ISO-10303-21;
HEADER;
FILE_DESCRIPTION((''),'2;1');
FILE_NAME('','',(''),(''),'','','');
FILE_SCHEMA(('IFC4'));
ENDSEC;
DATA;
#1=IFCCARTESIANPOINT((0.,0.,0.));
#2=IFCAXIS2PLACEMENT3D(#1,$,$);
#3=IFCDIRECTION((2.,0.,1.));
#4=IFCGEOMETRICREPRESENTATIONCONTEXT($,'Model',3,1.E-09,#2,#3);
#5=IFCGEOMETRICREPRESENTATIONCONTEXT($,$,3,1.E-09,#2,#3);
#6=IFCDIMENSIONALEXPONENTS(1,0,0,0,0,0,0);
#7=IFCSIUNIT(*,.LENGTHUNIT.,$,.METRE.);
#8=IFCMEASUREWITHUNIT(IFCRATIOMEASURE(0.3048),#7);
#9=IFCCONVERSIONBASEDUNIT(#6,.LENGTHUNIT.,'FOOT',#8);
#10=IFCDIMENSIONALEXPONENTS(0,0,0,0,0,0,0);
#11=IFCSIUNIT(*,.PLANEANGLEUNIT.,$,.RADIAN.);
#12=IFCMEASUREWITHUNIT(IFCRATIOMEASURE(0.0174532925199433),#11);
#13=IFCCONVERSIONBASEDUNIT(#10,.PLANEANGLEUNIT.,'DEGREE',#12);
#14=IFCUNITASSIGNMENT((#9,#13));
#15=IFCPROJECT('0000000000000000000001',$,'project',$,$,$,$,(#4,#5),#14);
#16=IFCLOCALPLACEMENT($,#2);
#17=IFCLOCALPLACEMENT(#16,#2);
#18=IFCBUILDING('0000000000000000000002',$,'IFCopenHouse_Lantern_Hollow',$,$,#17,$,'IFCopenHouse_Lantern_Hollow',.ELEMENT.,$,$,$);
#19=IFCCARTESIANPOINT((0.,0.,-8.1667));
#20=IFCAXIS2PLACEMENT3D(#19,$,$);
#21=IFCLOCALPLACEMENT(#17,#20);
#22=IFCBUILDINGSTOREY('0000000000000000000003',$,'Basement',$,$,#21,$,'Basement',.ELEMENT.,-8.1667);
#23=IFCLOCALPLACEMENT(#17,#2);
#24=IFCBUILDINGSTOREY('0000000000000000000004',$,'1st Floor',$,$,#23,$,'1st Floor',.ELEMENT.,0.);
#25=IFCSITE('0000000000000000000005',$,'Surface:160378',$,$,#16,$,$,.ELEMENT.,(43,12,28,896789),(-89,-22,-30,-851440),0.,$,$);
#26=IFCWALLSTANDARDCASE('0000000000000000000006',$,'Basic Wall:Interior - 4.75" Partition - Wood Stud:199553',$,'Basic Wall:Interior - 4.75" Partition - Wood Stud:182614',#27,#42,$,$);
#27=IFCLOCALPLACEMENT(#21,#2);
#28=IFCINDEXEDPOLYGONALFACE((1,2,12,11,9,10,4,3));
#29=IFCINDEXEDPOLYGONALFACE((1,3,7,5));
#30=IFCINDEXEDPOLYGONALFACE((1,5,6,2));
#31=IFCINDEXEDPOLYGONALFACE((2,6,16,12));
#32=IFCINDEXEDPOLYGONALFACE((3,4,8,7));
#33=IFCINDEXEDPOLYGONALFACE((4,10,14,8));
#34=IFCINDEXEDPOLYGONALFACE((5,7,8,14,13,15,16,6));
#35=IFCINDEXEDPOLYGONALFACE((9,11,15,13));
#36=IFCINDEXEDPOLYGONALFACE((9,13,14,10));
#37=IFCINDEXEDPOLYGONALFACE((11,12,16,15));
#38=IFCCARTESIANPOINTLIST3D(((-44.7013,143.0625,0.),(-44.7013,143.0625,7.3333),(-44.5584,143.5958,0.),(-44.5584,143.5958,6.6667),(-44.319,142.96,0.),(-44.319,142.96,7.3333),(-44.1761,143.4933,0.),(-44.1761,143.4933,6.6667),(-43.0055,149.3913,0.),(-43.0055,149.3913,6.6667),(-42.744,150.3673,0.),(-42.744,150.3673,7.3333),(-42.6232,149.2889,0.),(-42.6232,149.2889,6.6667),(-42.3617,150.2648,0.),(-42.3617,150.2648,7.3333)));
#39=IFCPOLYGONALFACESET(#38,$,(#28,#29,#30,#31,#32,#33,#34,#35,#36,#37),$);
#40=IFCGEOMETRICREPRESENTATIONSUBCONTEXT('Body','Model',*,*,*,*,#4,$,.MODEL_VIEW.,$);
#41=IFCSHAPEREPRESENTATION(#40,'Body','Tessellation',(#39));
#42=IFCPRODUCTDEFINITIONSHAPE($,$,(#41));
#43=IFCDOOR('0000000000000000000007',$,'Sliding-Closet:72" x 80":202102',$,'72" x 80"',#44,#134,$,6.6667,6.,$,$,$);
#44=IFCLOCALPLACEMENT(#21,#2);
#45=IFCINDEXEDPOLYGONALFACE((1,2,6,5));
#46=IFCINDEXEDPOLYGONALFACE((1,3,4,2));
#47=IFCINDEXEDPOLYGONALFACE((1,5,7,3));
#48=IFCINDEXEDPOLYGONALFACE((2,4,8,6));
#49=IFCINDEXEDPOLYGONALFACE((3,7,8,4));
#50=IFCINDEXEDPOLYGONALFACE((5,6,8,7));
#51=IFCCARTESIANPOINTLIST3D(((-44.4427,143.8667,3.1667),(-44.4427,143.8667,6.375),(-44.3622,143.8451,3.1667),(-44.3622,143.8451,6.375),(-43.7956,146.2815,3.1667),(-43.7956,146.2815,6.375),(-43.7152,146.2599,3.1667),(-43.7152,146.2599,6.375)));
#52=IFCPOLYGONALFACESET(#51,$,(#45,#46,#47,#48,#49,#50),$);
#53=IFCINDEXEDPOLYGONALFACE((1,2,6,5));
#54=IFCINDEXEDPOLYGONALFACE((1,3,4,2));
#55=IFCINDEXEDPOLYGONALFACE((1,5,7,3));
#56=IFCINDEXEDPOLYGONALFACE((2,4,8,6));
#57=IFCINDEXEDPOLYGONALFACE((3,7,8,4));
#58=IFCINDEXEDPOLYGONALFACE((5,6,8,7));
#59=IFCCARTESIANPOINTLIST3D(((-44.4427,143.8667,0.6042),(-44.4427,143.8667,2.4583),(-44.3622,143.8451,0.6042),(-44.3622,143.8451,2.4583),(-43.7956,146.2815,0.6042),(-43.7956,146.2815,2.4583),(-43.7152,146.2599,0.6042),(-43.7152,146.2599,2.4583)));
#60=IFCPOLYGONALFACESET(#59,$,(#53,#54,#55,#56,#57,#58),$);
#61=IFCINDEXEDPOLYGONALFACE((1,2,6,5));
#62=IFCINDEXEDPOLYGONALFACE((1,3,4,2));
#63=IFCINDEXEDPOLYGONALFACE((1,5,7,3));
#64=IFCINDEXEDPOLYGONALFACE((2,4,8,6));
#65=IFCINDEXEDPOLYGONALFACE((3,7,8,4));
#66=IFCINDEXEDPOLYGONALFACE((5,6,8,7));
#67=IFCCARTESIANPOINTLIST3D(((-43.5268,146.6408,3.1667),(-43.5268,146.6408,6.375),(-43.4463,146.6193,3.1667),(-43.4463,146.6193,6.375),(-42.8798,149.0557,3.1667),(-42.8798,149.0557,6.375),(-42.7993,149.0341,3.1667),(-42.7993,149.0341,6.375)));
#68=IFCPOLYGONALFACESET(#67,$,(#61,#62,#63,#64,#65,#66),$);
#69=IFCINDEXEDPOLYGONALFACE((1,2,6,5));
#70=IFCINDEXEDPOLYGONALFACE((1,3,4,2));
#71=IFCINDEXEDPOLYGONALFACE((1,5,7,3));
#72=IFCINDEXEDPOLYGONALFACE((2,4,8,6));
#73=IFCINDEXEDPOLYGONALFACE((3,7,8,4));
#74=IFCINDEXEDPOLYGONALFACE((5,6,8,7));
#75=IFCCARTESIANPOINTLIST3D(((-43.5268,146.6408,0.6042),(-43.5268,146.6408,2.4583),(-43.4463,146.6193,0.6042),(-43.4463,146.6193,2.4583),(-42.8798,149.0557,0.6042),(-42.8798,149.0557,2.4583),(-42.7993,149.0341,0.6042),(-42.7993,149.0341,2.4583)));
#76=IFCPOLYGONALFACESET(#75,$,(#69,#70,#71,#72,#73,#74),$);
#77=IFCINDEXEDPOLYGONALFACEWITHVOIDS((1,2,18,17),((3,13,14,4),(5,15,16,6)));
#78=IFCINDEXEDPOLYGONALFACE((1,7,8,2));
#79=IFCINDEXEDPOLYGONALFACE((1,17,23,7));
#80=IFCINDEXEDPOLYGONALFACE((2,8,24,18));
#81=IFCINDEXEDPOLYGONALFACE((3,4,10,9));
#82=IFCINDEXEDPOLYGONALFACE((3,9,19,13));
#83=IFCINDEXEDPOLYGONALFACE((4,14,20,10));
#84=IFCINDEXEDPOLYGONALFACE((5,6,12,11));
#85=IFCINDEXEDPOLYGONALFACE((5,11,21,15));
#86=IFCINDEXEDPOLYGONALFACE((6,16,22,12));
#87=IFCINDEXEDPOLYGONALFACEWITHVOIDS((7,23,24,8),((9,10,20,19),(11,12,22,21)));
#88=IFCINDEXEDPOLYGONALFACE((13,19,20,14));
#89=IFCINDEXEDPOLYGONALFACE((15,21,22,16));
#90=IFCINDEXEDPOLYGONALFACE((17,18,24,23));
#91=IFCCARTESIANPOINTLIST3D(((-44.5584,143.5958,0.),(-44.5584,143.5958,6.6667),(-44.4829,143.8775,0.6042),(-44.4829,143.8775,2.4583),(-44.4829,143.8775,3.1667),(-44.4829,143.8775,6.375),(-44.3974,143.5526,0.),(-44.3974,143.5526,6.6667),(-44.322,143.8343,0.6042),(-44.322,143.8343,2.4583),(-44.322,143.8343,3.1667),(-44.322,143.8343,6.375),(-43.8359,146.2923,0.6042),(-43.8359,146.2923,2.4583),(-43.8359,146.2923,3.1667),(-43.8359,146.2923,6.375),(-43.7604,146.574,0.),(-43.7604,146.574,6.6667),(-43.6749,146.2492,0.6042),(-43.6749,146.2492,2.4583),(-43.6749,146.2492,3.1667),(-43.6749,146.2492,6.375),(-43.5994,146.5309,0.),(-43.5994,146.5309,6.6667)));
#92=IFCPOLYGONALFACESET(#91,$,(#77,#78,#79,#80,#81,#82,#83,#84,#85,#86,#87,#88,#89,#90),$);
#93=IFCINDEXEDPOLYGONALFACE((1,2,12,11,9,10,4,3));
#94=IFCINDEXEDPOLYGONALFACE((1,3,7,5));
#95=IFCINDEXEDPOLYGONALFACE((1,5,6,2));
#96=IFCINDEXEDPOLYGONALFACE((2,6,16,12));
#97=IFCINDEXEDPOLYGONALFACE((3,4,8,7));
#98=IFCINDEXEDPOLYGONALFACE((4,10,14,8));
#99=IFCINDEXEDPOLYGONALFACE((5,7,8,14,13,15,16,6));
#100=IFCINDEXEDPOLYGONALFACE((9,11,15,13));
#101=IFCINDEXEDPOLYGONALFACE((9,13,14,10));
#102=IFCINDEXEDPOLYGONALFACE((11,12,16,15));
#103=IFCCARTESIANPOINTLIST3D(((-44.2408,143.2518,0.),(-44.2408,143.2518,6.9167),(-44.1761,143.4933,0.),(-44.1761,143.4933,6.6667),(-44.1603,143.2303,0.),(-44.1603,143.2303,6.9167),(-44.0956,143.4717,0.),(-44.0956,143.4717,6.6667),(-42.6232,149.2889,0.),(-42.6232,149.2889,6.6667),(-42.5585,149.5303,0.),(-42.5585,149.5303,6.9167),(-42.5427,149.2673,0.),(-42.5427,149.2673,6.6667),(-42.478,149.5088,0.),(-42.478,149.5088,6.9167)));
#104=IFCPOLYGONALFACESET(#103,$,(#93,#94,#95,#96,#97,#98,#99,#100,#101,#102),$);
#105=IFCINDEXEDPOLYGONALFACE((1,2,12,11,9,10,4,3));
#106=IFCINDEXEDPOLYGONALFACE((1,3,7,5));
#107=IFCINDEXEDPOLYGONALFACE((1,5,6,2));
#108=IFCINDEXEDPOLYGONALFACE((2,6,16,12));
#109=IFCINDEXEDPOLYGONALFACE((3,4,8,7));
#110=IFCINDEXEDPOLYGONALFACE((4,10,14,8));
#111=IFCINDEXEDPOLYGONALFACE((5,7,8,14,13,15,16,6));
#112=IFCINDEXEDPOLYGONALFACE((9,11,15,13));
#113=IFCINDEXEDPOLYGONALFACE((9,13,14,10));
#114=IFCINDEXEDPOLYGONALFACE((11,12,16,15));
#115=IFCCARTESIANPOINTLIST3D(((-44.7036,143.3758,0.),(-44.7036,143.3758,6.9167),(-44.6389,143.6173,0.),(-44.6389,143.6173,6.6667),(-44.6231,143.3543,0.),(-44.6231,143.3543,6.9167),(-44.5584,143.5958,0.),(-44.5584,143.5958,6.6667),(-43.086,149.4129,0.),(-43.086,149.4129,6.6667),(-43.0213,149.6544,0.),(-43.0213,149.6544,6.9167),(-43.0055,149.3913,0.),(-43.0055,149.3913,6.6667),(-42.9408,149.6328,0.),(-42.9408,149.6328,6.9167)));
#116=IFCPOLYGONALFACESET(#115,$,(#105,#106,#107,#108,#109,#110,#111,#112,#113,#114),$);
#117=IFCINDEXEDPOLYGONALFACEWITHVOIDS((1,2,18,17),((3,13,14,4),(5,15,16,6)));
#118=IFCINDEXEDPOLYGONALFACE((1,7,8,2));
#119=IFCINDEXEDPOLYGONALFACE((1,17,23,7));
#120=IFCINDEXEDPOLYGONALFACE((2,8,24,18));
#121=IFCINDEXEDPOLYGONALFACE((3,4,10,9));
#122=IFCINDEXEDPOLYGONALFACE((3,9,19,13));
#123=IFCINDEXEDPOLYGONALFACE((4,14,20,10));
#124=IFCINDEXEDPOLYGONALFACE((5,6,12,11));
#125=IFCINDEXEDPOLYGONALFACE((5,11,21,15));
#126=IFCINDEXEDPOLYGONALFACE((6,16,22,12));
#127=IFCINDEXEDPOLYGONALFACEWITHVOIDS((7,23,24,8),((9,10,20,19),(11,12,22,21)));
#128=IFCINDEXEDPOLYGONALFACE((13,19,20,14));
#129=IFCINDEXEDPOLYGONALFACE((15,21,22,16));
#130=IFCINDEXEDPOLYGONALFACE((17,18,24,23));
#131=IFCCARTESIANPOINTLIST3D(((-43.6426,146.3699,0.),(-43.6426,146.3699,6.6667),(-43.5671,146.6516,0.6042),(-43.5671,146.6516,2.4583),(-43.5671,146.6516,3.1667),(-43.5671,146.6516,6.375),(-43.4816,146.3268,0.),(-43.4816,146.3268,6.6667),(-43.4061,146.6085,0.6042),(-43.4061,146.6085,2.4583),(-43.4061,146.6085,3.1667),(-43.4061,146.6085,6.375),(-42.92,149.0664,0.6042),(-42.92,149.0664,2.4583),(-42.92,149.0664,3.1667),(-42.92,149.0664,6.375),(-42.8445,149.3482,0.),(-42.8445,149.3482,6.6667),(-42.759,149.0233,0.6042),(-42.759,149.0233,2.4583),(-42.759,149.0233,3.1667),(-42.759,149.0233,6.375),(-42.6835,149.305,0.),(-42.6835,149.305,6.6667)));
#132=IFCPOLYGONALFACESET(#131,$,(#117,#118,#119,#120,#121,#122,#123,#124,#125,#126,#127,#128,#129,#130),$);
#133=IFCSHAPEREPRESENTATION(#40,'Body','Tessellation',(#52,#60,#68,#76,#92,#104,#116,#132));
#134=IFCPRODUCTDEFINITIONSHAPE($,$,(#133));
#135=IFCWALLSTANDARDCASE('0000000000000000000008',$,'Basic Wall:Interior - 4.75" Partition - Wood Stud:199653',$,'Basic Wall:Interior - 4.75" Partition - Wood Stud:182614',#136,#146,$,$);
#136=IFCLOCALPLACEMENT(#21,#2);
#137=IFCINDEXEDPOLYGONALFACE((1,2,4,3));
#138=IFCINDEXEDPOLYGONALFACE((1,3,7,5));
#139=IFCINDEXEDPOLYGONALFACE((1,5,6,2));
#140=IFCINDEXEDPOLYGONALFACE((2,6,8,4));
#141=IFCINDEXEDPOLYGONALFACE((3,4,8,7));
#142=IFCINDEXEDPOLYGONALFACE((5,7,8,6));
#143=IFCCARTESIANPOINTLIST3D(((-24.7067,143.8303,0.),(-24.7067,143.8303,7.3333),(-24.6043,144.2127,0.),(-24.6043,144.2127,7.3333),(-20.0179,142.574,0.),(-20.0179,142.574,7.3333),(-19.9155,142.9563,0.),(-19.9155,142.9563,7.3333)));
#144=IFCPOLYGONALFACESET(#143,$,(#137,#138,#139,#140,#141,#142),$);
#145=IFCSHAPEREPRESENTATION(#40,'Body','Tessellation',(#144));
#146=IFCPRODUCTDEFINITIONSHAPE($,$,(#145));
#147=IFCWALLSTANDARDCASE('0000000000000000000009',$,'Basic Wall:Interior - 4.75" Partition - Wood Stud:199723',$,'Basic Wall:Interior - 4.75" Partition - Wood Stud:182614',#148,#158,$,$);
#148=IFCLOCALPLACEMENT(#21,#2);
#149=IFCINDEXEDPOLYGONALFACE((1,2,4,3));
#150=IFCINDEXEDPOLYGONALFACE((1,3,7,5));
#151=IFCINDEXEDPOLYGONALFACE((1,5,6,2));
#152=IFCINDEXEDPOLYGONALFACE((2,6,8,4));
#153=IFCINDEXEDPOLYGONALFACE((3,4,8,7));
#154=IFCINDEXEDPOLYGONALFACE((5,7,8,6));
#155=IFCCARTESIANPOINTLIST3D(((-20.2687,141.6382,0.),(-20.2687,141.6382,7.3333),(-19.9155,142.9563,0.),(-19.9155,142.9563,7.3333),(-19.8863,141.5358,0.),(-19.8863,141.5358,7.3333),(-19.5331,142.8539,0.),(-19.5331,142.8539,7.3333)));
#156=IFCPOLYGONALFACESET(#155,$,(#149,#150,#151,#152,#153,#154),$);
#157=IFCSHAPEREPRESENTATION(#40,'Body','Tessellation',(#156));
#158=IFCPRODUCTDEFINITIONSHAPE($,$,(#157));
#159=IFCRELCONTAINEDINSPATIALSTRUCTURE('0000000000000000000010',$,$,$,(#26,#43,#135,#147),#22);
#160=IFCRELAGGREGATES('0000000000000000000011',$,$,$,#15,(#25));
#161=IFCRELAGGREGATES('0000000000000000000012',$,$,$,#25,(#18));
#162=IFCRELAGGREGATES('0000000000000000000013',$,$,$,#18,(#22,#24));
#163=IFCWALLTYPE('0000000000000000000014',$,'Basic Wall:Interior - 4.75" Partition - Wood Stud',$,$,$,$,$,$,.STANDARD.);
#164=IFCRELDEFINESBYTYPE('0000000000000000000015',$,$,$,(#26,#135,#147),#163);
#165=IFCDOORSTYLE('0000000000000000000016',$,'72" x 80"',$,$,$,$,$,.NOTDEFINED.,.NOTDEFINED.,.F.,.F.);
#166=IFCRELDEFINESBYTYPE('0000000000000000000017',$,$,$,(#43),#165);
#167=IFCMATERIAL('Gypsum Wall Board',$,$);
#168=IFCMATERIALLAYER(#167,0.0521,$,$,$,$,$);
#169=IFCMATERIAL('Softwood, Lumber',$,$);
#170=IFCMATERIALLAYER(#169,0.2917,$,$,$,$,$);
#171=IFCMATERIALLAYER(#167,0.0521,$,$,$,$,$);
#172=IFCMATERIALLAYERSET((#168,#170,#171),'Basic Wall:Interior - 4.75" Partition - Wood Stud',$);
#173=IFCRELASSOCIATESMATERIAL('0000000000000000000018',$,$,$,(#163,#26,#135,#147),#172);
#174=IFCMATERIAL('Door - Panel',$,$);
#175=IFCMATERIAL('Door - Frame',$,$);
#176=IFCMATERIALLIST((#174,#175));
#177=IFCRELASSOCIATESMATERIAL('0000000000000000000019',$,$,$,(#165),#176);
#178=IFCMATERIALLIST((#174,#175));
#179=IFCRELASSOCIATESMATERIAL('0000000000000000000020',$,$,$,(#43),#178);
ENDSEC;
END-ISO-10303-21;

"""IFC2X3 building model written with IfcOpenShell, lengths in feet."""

from ifc_helpers import new_model, entity, si_unit, converted_unit, direction, frame, frame_2d, origin, origin_2d_with_axis, place, context, subcontext, project, spatial, polyline, rectangle, outline, extrude, source, transform, mapped, material, material_list, layer, layer_set, layer_usage, type_object, type_shapes, element, fill, save


model = new_model("IFC2X3")

# Units and contexts
model_context = context("Model", 3, precision=1e-09, world=origin(), true_north=direction((2.0, 0.0, 1.0)))
context_of_model = context(None, 3, precision=1e-09, world=origin(), true_north=direction((2.0, 0.0, 1.0)))
body_context = subcontext(model_context, "Body", "Model", "MODEL_VIEW")
ifc_project = project(units=[converted_unit("LENGTHUNIT", "FOOT", entity("IfcRatioMeasure", 0.3048), si_unit("LENGTHUNIT", "METRE"), dimensions=[1, 0, 0, 0, 0, 0, 0]), converted_unit("PLANEANGLEUNIT", "DEGREE", entity("IfcRatioMeasure", 0.0174532925199433), si_unit("PLANEANGLEUNIT", "RADIAN"), dimensions=[0, 0, 0, 0, 0, 0, 0])], contexts=[model_context, context_of_model])

# Site, building, storey
site_placement = place(None, origin())
site = spatial("IfcSite", under=ifc_project, at=site_placement, Name="Surface:160378", CompositionType="ELEMENT", RefLatitude=(43, 12, 28, 896789), RefLongitude=(-89, -22, -30, -851440), RefElevation=0.0)
building_placement = place(site_placement, origin())
building = spatial("IfcBuilding", under=site, at=building_placement, Name="IFCopenHouse_Lantern_Hollow", LongName="IFCopenHouse_Lantern_Hollow", CompositionType="ELEMENT")
storey_1_placement = place(building_placement, frame((0.0, 0.0, -8.1667)))
storey_1 = spatial("IfcBuildingStorey", under=building, at=storey_1_placement, Name="Basement", LongName="Basement", CompositionType="ELEMENT", Elevation=-8.1667)

# Shared definitions
ifc_material_1 = material(Name="Softwood, Lumber")
ifc_material_2 = material(Name="Gypsum Wall Board")

# Shared definitions
ifc_layer_1 = layer(ifc_material_2, 0.0521)
ifc_layer_2 = layer(ifc_material_1, 0.2917)
ifc_layer_3 = layer(ifc_material_2, 0.0521)
ifc_layer_set_1 = layer_set([ifc_layer_1, ifc_layer_2, ifc_layer_3], Name="Basic Wall:Interior - 4.75\" Partition - Wood Stud")
wall_type_1 = type_object("IfcWallType", Name="Basic Wall:Interior - 4.75\" Partition - Wood Stud", PredefinedType="STANDARD", material=ifc_layer_set_1)

# Shared definitions
ifc_material_3 = material(Name="Door - Frame")
ifc_material_4 = material(Name="Door - Panel")

# Wall, opening, door
ifc_layer_usage_1 = layer_usage(ifc_layer_set_1, "AXIS2", "NEGATIVE", 0.1979)
wall_1_placement = place(storey_1_placement, frame((-42.5528, 150.3161, 0.0), z_axis=(0.0, 0.0, 1.0), x_axis=(-0.258819, -0.965926, 0.0)))
wall_1 = element("IfcWallStandardCase", 1, at=wall_1_placement, inside=storey_1, type_object=wall_type_1, material=ifc_layer_usage_1, Name="Basic Wall:Interior - 4.75\" Partition - Wood Stud:199553", ObjectType="Basic Wall:Interior - 4.75\" Partition - Wood Stud:182614", context=body_context, shape_type="SweptSolid", body=[
    extrude(rectangle(XDim=7.5625, YDim=0.3958, at=frame_2d((3.7813, 0.0), x_axis=(-1.0, 0.0))), origin(), (0.0, 0.0, 1.0), 7.3333),
])
opening_1_placement = place(wall_1_placement, frame((7.0104, 0.1979, 0.0)))
opening_1 = element("IfcOpeningElement", 2, at=opening_1_placement, cuts=wall_1, ObjectType="Opening", context=body_context, shape_type="SweptSolid", body=[
    extrude(rectangle(XDim=6.6667, YDim=6.0, at=frame_2d((3.3333, 3.0), x_axis=(-1.0, 0.0))), frame((0.0, 0.0, 0.0), z_axis=(0.0, -1.0, 0.0), x_axis=(0.0, 0.0, 1.0)), (0.0, 0.0, 1.0), 0.3958),
])
ifc_material_list_1 = material_list([ifc_material_4, ifc_material_3])
ifc_material_list_2 = material_list([ifc_material_4, ifc_material_3])
door_style_1 = type_object("IfcDoorStyle", Name="72\" x 80\"", ConstructionType="NOTDEFINED", OperationType="NOTDEFINED", ParameterTakesPrecedence=False, Sizeable=False, material=ifc_material_list_2)
shared_shape_1 = source(origin(), body_context, "Body", "SweptSolid", [
    extrude(rectangle(XDim=0.0833, YDim=2.5, at=origin_2d_with_axis()), frame((1.5417, 0.3125, 3.1667), z_axis=(0.0, 0.0, 1.0), x_axis=(0.0, 1.0, 0.0)), (0.0, 0.0, 1.0), 3.2083),
    extrude(rectangle(XDim=0.0833, YDim=2.5, at=origin_2d_with_axis()), frame((1.5417, 0.3125, 0.6042), z_axis=(0.0, 0.0, 1.0), x_axis=(0.0, 1.0, 0.0)), (0.0, 0.0, 1.0), 1.8542),
    extrude(rectangle(XDim=0.0833, YDim=2.5, at=origin_2d_with_axis()), frame((4.4583, 0.1458, 3.1667), z_axis=(0.0, 0.0, 1.0), x_axis=(0.0, -1.0, 0.0)), (0.0, 0.0, 1.0), 3.2083),
    extrude(rectangle(XDim=0.0833, YDim=2.5, at=origin_2d_with_axis()), frame((4.4583, 0.1458, 0.6042), z_axis=(0.0, 0.0, 1.0), x_axis=(0.0, -1.0, 0.0)), (0.0, 0.0, 1.0), 1.8542),
    extrude(outline(polyline([(-3.3333, -1.5417), (3.3333, -1.5417), (3.3333, 1.5417), (-3.3333, 1.5417), (-3.3333, -1.5417)]), holes=[polyline([(2.7292, 1.25), (2.7292, -1.25), (0.875, -1.25), (0.875, 1.25), (2.7292, 1.25)]), polyline([(0.1667, 1.25), (0.1667, -1.25), (-3.0417, -1.25), (-3.0417, 1.25), (0.1667, 1.25)])]), frame((1.5417, 0.2292, 3.3333), z_axis=(0.0, 1.0, 0.0), x_axis=(0.0, 0.0, -1.0)), (0.0, 0.0, 1.0), 0.1667),
    extrude(outline(polyline([(-3.3958, -3.25), (3.5208, -3.25), (3.5208, 3.25), (-3.3958, 3.25), (-3.3958, 3.0), (3.2708, 3.0), (3.2708, -3.0), (-3.3958, -3.0), (-3.3958, -3.25)])), frame((3.0, -0.0833, 3.3958), z_axis=(0.0, 1.0, 0.0), x_axis=(0.0, 0.0, 1.0)), (0.0, 0.0, 1.0), 0.0833),
    extrude(outline(polyline([(-3.25, -3.3958), (-3.0, -3.3958), (-3.0, 3.2708), (3.0, 3.2708), (3.0, -3.3958), (3.25, -3.3958), (3.25, 3.5208), (-3.25, 3.5208), (-3.25, -3.3958)])), frame((3.0, 0.3958, 3.3958), z_axis=(0.0, 1.0, 0.0), x_axis=(-1.0, 0.0, 0.0)), (0.0, 0.0, 1.0), 0.0833),
    extrude(outline(polyline([(-1.5417, -3.3333), (1.5417, -3.3333), (1.5417, 3.3333), (-1.5417, 3.3333), (-1.5417, -3.3333)]), holes=[polyline([(1.25, 0.1667), (1.25, -3.0417), (-1.25, -3.0417), (-1.25, 0.1667), (1.25, 0.1667)]), polyline([(1.25, 2.7292), (1.25, 0.875), (-1.25, 0.875), (-1.25, 2.7292), (1.25, 2.7292)])]), frame((4.4583, 0.0625, 3.3333), z_axis=(0.0, 1.0, 0.0), x_axis=(1.0, 0.0, 0.0)), (0.0, 0.0, 1.0), 0.1667),
])
type_shapes(door_style_1, [shared_shape_1])
door_1_placement = place(storey_1_placement, frame((-44.1761, 143.4933, 0.0), z_axis=(0.0, 0.0, 1.0), x_axis=(0.258819, 0.965926, 0.0)))
door_1 = element("IfcDoor", 3, at=door_1_placement, inside=storey_1, type_object=door_style_1, material=ifc_material_list_1, Name="Sliding-Closet:72\" x 80\":202102", ObjectType="72\" x 80\"", OverallHeight=6.6667, OverallWidth=6.0, context=body_context, shape_type="MappedRepresentation", body=[
    mapped(shared_shape_1, transform((0.0, 0.0, 0.0), scale=1.0)),
])
fill(opening_1, door_1)

# Walls
ifc_layer_usage_2 = layer_usage(ifc_layer_set_1, "AXIS2", "NEGATIVE", 0.1979)
wall_2_placement = place(storey_1_placement, frame((-24.6555, 144.0215, 0.0), z_axis=(0.0, 0.0, 1.0), x_axis=(0.965926, -0.258819, 0.0)))
element("IfcWallStandardCase", 4, at=wall_2_placement, inside=storey_1, type_object=wall_type_1, material=ifc_layer_usage_2, Name="Basic Wall:Interior - 4.75\" Partition - Wood Stud:199653", ObjectType="Basic Wall:Interior - 4.75\" Partition - Wood Stud:182614", context=body_context, shape_type="SweptSolid", body=[
    extrude(rectangle(XDim=4.8542, YDim=0.3958, at=frame_2d((2.4271, 0.0), x_axis=(-1.0, 0.0))), origin(), (0.0, 0.0, 1.0), 7.3333),
])
ifc_layer_usage_3 = layer_usage(ifc_layer_set_1, "AXIS2", "NEGATIVE", 0.1979)
wall_3_placement = place(storey_1_placement, frame((-20.0775, 141.587, 0.0), z_axis=(0.0, 0.0, 1.0), x_axis=(0.258819, 0.965926, 0.0)))
element("IfcWallStandardCase", 5, at=wall_3_placement, inside=storey_1, type_object=wall_type_1, material=ifc_layer_usage_3, Name="Basic Wall:Interior - 4.75\" Partition - Wood Stud:199723", ObjectType="Basic Wall:Interior - 4.75\" Partition - Wood Stud:182614", context=body_context, shape_type="SweptSolid", body=[
    extrude(rectangle(XDim=1.3646, YDim=0.3958, at=frame_2d((0.6823, 0.0), x_axis=(-1.0, 0.0))), origin(), (0.0, 0.0, 1.0), 7.3333),
])

# Shared definitions
storey_2_placement = place(building_placement, origin())
storey_2 = spatial("IfcBuildingStorey", under=building, at=storey_2_placement, Name="1st Floor", LongName="1st Floor", CompositionType="ELEMENT", Elevation=0.0)

save(model, "model.ifc")
